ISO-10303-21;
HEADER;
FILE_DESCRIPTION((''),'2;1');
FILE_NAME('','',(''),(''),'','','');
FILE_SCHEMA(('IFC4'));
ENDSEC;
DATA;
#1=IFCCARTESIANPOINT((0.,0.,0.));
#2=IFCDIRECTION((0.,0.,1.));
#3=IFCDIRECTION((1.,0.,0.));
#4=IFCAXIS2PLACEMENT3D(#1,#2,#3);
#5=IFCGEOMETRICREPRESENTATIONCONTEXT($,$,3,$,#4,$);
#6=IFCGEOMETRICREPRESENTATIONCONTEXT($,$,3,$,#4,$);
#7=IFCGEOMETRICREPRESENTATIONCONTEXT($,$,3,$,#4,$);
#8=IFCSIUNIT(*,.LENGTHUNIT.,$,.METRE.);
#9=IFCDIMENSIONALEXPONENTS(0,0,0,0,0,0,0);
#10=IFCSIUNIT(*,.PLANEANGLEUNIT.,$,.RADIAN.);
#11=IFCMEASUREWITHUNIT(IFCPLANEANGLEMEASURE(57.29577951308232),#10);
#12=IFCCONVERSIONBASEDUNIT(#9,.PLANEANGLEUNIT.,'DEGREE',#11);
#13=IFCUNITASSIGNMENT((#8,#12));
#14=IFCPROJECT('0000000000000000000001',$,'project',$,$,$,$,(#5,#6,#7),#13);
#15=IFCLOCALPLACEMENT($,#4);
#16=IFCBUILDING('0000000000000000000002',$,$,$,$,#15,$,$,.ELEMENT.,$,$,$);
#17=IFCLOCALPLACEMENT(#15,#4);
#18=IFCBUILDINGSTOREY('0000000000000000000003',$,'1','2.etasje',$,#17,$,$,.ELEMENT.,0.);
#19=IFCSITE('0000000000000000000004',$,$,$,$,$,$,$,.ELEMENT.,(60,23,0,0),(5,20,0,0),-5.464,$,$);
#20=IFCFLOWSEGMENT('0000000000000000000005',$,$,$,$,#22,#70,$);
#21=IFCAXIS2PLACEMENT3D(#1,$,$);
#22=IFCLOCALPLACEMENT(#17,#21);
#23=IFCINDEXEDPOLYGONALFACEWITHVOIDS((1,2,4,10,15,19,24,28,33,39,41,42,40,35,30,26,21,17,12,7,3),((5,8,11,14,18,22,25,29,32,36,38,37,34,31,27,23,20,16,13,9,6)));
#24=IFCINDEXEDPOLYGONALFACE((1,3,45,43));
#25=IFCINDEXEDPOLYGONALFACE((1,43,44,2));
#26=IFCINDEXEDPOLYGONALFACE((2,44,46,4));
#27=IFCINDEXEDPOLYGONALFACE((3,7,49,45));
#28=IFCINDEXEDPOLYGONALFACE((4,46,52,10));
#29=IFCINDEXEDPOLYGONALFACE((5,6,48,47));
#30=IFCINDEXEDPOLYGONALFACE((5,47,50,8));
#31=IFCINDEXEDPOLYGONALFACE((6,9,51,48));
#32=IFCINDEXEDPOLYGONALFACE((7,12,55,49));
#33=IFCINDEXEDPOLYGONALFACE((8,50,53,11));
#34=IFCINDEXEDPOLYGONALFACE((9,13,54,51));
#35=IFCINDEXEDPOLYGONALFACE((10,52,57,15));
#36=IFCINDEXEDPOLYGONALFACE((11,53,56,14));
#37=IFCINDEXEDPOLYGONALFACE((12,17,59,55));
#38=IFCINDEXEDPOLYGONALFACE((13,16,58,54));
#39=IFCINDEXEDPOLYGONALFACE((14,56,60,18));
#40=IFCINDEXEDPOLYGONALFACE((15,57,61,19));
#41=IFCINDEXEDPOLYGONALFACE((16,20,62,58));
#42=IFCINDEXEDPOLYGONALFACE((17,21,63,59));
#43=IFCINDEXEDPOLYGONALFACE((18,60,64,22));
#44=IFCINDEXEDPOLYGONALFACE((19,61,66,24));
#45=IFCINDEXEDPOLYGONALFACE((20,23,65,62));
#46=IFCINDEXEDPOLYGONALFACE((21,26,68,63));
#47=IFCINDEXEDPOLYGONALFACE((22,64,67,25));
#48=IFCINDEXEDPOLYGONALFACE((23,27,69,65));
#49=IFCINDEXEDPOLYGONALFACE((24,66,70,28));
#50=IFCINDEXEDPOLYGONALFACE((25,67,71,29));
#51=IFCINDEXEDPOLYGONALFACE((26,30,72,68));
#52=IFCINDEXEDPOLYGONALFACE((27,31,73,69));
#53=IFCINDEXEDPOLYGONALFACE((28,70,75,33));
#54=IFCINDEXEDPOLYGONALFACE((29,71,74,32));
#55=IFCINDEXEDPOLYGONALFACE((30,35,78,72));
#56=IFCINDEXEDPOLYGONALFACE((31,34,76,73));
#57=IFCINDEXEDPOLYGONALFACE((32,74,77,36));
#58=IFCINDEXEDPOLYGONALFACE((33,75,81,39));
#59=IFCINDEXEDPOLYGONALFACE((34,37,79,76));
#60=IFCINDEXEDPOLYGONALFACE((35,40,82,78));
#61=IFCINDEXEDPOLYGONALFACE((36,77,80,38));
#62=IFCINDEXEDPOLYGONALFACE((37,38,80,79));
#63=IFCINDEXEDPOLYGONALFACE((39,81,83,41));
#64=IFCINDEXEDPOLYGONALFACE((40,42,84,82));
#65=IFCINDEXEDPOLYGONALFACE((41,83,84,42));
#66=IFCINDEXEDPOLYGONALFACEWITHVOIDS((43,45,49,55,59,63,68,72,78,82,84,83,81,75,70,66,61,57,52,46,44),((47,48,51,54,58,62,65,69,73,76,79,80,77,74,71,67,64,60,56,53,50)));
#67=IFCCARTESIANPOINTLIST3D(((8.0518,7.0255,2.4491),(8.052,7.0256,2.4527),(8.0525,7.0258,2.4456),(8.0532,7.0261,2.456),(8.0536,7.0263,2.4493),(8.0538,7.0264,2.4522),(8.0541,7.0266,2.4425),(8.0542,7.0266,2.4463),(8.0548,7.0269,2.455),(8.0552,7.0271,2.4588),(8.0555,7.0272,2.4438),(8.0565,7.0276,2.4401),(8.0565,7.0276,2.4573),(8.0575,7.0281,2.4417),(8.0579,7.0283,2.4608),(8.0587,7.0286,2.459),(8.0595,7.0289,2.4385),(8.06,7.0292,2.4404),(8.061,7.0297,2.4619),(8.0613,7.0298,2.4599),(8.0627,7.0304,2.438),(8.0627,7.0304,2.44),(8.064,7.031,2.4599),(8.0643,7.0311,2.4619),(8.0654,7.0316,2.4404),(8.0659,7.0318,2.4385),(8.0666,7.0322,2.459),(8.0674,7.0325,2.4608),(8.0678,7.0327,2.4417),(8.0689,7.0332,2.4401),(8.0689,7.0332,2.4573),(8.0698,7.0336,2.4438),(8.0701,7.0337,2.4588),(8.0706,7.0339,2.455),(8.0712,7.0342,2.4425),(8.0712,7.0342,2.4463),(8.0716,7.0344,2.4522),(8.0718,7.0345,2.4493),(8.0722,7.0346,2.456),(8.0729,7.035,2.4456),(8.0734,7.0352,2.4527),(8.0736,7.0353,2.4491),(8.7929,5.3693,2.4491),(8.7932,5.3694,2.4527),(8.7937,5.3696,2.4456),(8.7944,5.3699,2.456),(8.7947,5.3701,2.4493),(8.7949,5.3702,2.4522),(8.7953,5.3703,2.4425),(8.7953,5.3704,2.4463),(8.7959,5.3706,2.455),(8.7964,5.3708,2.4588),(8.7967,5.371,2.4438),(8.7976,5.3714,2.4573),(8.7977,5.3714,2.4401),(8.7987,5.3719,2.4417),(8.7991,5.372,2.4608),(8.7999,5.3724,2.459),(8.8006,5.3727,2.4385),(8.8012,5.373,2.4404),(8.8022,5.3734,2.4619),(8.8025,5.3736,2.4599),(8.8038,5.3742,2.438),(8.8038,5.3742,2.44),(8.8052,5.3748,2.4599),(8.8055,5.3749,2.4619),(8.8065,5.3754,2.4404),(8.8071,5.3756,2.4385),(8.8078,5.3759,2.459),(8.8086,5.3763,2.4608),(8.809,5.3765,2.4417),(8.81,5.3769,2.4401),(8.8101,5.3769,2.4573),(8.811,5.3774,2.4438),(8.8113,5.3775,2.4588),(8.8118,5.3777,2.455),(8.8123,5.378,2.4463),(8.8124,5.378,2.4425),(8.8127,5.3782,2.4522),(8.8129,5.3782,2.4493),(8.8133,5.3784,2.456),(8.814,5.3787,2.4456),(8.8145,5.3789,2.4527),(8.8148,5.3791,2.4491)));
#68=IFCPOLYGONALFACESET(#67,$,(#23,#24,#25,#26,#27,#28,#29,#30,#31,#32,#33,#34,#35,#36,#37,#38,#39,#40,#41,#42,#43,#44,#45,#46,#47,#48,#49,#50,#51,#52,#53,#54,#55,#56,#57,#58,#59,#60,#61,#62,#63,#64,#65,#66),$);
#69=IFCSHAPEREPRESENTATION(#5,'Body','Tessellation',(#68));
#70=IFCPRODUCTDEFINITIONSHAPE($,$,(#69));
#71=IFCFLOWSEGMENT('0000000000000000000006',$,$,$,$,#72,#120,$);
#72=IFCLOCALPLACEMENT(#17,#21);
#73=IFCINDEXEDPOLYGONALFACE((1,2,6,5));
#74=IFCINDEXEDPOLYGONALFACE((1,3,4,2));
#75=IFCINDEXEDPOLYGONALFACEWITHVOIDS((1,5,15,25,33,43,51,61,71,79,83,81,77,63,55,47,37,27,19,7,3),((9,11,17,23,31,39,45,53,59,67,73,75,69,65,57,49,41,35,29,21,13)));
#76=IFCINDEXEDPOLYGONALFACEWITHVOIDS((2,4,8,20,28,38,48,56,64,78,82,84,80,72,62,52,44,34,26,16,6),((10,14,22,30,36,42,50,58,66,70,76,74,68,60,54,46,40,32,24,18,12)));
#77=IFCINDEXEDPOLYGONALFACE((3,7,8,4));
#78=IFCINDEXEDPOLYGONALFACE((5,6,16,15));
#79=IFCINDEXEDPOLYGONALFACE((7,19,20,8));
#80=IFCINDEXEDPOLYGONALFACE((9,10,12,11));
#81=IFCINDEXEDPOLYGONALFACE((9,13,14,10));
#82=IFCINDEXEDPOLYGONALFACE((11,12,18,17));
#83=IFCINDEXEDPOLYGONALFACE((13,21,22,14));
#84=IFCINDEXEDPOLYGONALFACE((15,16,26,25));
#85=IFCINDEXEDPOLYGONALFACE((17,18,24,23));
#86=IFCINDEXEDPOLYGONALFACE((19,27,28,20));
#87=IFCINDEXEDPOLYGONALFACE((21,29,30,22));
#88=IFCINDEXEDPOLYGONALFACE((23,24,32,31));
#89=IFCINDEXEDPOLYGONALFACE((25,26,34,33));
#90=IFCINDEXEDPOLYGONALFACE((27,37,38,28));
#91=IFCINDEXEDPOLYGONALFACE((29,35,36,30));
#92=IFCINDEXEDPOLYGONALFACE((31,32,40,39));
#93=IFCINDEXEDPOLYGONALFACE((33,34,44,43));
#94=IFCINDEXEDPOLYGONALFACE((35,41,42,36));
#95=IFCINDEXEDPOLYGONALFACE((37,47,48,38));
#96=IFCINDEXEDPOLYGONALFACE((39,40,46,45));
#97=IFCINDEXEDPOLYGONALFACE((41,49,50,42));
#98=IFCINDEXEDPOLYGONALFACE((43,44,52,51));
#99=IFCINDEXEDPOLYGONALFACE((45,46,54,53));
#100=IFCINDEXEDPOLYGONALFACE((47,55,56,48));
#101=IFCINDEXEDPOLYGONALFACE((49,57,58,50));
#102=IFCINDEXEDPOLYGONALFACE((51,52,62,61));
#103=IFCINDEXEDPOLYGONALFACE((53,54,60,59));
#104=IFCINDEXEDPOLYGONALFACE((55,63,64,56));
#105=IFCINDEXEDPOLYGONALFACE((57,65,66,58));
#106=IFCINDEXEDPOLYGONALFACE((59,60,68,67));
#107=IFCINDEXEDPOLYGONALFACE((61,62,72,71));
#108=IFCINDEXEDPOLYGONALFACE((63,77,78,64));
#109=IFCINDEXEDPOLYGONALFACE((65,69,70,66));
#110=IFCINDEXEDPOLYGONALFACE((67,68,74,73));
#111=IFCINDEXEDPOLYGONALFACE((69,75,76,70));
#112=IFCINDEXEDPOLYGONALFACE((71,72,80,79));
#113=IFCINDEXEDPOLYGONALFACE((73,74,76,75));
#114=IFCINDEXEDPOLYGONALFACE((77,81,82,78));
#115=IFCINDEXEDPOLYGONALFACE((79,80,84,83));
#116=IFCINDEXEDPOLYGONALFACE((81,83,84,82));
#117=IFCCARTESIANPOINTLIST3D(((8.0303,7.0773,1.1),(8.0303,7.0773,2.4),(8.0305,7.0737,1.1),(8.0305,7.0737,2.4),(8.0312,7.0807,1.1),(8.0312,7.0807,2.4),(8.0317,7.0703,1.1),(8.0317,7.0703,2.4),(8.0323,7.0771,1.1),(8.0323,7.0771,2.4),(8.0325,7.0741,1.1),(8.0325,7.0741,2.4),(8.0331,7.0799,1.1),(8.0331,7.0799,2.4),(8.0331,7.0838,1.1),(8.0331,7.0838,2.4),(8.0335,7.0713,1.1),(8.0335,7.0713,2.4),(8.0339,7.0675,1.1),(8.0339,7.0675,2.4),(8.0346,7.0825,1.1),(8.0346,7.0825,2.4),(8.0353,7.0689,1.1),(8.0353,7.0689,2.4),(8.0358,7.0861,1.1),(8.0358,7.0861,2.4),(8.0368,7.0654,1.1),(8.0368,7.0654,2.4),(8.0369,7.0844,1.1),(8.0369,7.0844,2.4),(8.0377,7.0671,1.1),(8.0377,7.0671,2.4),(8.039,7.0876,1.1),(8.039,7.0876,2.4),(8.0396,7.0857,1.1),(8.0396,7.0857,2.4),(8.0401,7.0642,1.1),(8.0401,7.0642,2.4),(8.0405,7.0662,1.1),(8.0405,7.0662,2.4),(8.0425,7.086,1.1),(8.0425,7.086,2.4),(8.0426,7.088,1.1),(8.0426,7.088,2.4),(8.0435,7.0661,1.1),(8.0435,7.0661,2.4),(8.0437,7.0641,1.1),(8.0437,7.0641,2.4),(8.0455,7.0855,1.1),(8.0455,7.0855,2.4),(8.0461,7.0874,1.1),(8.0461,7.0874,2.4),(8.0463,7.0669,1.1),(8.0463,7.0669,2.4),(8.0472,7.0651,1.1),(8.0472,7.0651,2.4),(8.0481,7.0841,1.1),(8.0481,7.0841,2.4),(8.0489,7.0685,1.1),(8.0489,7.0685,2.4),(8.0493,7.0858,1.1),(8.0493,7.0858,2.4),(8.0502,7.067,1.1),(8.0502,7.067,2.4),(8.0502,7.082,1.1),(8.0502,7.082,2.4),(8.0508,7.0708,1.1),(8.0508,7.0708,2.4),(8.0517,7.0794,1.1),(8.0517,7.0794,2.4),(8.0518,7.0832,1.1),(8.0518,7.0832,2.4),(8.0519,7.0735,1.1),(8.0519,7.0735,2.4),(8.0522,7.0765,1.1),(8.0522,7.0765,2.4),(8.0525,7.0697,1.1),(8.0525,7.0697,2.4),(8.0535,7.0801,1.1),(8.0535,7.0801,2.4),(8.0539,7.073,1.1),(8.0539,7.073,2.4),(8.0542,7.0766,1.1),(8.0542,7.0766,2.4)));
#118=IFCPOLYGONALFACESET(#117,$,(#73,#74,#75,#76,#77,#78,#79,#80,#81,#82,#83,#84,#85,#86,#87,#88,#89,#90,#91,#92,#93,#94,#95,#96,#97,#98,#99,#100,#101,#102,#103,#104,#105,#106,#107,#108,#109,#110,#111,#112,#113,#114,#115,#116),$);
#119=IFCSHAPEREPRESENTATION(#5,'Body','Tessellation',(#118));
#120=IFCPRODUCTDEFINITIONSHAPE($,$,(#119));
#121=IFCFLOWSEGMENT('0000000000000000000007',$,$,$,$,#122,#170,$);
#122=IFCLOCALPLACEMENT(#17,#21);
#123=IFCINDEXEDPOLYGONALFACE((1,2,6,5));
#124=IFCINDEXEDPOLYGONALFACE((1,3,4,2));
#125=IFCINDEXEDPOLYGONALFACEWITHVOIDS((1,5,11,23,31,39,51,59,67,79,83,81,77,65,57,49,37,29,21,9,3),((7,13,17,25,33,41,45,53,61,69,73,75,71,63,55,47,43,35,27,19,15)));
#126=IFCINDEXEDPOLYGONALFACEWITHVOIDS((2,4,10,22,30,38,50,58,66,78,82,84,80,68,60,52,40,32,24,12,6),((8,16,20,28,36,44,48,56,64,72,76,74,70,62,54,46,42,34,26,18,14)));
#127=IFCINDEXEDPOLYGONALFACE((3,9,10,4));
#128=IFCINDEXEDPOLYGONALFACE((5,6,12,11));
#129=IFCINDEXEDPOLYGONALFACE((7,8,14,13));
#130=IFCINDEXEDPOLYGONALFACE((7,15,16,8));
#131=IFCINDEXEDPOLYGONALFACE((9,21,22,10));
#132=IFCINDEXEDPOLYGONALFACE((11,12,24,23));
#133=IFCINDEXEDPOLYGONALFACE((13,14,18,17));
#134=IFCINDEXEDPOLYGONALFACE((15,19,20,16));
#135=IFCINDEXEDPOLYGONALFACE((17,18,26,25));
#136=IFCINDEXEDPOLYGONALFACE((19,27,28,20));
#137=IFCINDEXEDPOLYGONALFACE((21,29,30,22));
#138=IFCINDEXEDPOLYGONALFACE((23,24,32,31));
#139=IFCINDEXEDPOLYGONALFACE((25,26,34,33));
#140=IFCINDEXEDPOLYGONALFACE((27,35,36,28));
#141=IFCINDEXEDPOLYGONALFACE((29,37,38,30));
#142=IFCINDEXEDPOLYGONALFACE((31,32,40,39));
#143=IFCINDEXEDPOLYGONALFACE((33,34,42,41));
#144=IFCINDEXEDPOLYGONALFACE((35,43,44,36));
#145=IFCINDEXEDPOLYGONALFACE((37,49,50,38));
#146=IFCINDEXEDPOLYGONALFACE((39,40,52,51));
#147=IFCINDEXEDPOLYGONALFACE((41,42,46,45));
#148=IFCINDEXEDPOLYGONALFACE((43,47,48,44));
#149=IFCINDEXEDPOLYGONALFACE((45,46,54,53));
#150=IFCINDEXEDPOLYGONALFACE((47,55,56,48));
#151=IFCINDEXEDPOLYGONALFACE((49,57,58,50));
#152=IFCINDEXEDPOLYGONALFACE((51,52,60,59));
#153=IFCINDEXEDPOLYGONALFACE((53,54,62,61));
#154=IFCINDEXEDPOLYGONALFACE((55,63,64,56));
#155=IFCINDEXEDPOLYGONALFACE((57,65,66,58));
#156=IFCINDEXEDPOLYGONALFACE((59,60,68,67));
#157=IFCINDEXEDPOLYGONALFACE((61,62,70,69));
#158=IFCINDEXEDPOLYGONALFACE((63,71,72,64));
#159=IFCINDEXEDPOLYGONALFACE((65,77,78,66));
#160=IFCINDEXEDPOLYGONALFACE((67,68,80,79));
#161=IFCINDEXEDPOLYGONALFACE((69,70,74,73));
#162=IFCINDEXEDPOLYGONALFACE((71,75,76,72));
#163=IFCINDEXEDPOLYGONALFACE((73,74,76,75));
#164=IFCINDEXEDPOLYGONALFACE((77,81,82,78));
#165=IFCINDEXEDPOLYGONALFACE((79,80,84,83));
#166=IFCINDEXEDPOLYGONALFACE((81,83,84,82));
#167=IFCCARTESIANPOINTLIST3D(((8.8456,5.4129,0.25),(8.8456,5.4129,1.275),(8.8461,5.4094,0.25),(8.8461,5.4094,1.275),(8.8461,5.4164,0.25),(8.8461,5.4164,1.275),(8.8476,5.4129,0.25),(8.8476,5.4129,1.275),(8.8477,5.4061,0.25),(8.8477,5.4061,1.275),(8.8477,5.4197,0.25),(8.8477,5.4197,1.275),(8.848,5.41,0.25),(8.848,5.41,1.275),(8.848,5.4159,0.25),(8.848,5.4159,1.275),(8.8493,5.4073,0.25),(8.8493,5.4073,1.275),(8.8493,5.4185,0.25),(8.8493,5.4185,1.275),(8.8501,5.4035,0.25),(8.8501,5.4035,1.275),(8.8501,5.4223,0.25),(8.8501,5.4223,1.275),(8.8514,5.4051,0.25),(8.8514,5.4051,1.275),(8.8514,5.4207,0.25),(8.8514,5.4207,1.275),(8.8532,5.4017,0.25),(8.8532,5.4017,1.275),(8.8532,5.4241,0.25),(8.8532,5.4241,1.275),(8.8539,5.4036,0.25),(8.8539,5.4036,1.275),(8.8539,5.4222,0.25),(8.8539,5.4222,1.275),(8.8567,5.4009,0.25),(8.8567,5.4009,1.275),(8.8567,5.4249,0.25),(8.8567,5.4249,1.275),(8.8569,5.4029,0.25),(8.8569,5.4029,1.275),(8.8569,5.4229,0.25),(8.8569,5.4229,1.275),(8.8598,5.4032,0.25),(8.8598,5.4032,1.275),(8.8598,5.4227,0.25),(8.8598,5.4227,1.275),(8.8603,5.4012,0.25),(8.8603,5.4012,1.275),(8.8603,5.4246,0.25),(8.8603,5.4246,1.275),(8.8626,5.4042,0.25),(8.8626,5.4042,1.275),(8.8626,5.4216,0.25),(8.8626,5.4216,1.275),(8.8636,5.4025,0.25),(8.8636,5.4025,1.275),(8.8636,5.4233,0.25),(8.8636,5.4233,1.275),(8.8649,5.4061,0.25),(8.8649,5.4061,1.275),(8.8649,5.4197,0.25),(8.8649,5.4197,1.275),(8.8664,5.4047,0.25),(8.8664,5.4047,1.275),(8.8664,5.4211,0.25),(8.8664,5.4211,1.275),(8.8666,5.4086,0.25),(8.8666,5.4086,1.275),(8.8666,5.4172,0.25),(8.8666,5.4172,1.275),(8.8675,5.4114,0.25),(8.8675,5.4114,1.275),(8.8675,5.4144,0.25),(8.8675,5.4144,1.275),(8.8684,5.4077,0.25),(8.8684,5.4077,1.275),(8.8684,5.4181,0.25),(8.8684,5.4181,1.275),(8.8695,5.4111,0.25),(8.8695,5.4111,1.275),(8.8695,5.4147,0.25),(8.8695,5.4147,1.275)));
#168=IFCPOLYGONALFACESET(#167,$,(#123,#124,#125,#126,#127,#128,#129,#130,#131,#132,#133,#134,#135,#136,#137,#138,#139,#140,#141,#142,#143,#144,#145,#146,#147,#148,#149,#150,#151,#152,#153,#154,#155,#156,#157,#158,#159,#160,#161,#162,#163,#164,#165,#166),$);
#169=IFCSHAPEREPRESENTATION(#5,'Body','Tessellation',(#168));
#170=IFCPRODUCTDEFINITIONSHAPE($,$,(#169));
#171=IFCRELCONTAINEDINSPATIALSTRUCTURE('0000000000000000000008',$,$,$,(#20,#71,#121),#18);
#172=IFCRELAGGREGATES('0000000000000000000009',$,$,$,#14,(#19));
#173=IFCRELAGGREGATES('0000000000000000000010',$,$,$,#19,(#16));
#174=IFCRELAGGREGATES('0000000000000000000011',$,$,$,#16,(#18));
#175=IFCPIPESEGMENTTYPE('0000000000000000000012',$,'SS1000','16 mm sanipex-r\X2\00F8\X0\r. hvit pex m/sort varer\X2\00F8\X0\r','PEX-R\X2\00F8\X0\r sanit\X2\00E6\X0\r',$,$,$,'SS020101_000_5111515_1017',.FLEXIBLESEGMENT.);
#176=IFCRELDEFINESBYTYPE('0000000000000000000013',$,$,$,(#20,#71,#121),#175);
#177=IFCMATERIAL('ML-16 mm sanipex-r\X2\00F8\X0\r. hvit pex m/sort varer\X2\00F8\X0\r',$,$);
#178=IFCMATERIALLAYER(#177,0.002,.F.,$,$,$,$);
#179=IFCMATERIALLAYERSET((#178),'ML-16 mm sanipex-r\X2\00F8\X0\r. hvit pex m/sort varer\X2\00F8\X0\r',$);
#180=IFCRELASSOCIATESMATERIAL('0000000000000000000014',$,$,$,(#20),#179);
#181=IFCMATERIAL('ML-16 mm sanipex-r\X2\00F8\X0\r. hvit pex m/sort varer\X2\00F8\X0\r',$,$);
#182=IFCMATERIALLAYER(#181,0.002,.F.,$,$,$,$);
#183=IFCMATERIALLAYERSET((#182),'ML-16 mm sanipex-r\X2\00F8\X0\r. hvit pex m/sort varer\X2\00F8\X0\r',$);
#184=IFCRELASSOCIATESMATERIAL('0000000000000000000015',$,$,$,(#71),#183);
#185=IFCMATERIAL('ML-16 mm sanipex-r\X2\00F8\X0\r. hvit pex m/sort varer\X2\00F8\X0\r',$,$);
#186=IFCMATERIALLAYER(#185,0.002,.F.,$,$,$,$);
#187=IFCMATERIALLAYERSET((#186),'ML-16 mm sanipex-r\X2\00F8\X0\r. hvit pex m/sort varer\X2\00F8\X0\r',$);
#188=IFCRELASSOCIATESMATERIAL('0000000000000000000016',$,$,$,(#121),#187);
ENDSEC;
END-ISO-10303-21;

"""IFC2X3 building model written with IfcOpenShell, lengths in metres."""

from ifc_helpers import new_model, entity, si_unit, converted_unit, frame, origin_with_axes, origin_2d_with_axis, place, context, project, spatial, hollow_circle, extrude, material, layer, layer_set, layer_usage, type_object, element, save


model = new_model("IFC2X3")

# Units and contexts
context_of_model_1 = context(None, 3, world=origin_with_axes())
context_of_model_2 = context(None, 3, world=origin_with_axes())
context_of_model_3 = context(None, 3, world=origin_with_axes())
ifc_project = project(units=[si_unit("LENGTHUNIT", "METRE"), converted_unit("PLANEANGLEUNIT", "DEGREE", entity("IfcPlaneAngleMeasure", 57.29577951308232), si_unit("PLANEANGLEUNIT", "RADIAN"), dimensions=[0, 0, 0, 0, 0, 0, 0])], contexts=[context_of_model_1, context_of_model_2, context_of_model_3])

# Site, building, storey
site = spatial("IfcSite", under=ifc_project, CompositionType="ELEMENT", RefLatitude=(60, 23, 0, 0), RefLongitude=(5, 20, 0, 0), RefElevation=-5.464)
building_placement = place(None, origin_with_axes())
building = spatial("IfcBuilding", under=site, at=building_placement, CompositionType="ELEMENT")
storey_placement = place(building_placement, origin_with_axes())
storey = spatial("IfcBuildingStorey", under=building, at=storey_placement, Name="1", Description="2.etasje", CompositionType="ELEMENT", Elevation=0.0)

# Flow segments
pipe_segment_type_1 = type_object("IfcPipeSegmentType", Name="SS1000", Description="16 mm sanipex-rør. hvit pex m/sort varerør", ApplicableOccurrence="PEX-Rør sanitær", ElementType="SS020101_000_5111515_1017", PredefinedType="FLEXIBLESEGMENT")
ifc_material_1 = material(Name="ML-16 mm sanipex-rør. hvit pex m/sort varerør")
ifc_layer_1 = layer(ifc_material_1, 0.002, ventilated=False)
ifc_layer_set_1 = layer_set([ifc_layer_1], Name="ML-16 mm sanipex-rør. hvit pex m/sort varerør")
ifc_layer_usage_1 = layer_usage(ifc_layer_set_1, "AXIS2", "POSITIVE", 0.0)
flow_segment_1_placement = place(storey_placement, frame((8.8038, 5.3742, 2.45), z_axis=(-0.408468, 0.912773, 0.0), x_axis=(0.0, 0.0, -1.0)))
element("IfcFlowSegment", 1, at=flow_segment_1_placement, inside=storey, type_object=pipe_segment_type_1, material=ifc_layer_usage_1, context=context_of_model_1, shape_type="SweptSolid", body=[
    extrude(hollow_circle(Radius=0.012, WallThickness=0.002, at=origin_2d_with_axis()), origin_with_axes(), (0.0, 0.0, 1.0), 1.8145),
])
ifc_material_2 = material(Name="ML-16 mm sanipex-rør. hvit pex m/sort varerør")
ifc_layer_2 = layer(ifc_material_2, 0.002, ventilated=False)
ifc_layer_set_2 = layer_set([ifc_layer_2], Name="ML-16 mm sanipex-rør. hvit pex m/sort varerør")
ifc_layer_usage_2 = layer_usage(ifc_layer_set_2, "AXIS2", "POSITIVE", 0.0)
flow_segment_2_placement = place(storey_placement, frame((8.0423, 7.076, 2.4), z_axis=(0.0, 0.0, -1.0), x_axis=(0.408468, -0.912773, 0.0)))
element("IfcFlowSegment", 2, at=flow_segment_2_placement, inside=storey, type_object=pipe_segment_type_1, material=ifc_layer_usage_2, context=context_of_model_1, shape_type="SweptSolid", body=[
    extrude(hollow_circle(Radius=0.012, WallThickness=0.002, at=origin_2d_with_axis()), origin_with_axes(), (0.0, 0.0, 1.0), 1.3),
])
ifc_material_3 = material(Name="ML-16 mm sanipex-rør. hvit pex m/sort varerør")
ifc_layer_3 = layer(ifc_material_3, 0.002, ventilated=False)
ifc_layer_set_3 = layer_set([ifc_layer_3], Name="ML-16 mm sanipex-rør. hvit pex m/sort varerør")
ifc_layer_usage_3 = layer_usage(ifc_layer_set_3, "AXIS2", "POSITIVE", 0.0)
flow_segment_3_placement = place(storey_placement, frame((8.8576, 5.4129, 1.275), z_axis=(0.0, 0.0, -1.0), x_axis=(-1.0, 0.0, 0.0)))
element("IfcFlowSegment", 3, at=flow_segment_3_placement, inside=storey, type_object=pipe_segment_type_1, material=ifc_layer_usage_3, context=context_of_model_1, shape_type="SweptSolid", body=[
    extrude(hollow_circle(Radius=0.012, WallThickness=0.002, at=origin_2d_with_axis()), origin_with_axes(), (0.0, 0.0, 1.0), 1.025),
])

save(model, "model.ifc")
